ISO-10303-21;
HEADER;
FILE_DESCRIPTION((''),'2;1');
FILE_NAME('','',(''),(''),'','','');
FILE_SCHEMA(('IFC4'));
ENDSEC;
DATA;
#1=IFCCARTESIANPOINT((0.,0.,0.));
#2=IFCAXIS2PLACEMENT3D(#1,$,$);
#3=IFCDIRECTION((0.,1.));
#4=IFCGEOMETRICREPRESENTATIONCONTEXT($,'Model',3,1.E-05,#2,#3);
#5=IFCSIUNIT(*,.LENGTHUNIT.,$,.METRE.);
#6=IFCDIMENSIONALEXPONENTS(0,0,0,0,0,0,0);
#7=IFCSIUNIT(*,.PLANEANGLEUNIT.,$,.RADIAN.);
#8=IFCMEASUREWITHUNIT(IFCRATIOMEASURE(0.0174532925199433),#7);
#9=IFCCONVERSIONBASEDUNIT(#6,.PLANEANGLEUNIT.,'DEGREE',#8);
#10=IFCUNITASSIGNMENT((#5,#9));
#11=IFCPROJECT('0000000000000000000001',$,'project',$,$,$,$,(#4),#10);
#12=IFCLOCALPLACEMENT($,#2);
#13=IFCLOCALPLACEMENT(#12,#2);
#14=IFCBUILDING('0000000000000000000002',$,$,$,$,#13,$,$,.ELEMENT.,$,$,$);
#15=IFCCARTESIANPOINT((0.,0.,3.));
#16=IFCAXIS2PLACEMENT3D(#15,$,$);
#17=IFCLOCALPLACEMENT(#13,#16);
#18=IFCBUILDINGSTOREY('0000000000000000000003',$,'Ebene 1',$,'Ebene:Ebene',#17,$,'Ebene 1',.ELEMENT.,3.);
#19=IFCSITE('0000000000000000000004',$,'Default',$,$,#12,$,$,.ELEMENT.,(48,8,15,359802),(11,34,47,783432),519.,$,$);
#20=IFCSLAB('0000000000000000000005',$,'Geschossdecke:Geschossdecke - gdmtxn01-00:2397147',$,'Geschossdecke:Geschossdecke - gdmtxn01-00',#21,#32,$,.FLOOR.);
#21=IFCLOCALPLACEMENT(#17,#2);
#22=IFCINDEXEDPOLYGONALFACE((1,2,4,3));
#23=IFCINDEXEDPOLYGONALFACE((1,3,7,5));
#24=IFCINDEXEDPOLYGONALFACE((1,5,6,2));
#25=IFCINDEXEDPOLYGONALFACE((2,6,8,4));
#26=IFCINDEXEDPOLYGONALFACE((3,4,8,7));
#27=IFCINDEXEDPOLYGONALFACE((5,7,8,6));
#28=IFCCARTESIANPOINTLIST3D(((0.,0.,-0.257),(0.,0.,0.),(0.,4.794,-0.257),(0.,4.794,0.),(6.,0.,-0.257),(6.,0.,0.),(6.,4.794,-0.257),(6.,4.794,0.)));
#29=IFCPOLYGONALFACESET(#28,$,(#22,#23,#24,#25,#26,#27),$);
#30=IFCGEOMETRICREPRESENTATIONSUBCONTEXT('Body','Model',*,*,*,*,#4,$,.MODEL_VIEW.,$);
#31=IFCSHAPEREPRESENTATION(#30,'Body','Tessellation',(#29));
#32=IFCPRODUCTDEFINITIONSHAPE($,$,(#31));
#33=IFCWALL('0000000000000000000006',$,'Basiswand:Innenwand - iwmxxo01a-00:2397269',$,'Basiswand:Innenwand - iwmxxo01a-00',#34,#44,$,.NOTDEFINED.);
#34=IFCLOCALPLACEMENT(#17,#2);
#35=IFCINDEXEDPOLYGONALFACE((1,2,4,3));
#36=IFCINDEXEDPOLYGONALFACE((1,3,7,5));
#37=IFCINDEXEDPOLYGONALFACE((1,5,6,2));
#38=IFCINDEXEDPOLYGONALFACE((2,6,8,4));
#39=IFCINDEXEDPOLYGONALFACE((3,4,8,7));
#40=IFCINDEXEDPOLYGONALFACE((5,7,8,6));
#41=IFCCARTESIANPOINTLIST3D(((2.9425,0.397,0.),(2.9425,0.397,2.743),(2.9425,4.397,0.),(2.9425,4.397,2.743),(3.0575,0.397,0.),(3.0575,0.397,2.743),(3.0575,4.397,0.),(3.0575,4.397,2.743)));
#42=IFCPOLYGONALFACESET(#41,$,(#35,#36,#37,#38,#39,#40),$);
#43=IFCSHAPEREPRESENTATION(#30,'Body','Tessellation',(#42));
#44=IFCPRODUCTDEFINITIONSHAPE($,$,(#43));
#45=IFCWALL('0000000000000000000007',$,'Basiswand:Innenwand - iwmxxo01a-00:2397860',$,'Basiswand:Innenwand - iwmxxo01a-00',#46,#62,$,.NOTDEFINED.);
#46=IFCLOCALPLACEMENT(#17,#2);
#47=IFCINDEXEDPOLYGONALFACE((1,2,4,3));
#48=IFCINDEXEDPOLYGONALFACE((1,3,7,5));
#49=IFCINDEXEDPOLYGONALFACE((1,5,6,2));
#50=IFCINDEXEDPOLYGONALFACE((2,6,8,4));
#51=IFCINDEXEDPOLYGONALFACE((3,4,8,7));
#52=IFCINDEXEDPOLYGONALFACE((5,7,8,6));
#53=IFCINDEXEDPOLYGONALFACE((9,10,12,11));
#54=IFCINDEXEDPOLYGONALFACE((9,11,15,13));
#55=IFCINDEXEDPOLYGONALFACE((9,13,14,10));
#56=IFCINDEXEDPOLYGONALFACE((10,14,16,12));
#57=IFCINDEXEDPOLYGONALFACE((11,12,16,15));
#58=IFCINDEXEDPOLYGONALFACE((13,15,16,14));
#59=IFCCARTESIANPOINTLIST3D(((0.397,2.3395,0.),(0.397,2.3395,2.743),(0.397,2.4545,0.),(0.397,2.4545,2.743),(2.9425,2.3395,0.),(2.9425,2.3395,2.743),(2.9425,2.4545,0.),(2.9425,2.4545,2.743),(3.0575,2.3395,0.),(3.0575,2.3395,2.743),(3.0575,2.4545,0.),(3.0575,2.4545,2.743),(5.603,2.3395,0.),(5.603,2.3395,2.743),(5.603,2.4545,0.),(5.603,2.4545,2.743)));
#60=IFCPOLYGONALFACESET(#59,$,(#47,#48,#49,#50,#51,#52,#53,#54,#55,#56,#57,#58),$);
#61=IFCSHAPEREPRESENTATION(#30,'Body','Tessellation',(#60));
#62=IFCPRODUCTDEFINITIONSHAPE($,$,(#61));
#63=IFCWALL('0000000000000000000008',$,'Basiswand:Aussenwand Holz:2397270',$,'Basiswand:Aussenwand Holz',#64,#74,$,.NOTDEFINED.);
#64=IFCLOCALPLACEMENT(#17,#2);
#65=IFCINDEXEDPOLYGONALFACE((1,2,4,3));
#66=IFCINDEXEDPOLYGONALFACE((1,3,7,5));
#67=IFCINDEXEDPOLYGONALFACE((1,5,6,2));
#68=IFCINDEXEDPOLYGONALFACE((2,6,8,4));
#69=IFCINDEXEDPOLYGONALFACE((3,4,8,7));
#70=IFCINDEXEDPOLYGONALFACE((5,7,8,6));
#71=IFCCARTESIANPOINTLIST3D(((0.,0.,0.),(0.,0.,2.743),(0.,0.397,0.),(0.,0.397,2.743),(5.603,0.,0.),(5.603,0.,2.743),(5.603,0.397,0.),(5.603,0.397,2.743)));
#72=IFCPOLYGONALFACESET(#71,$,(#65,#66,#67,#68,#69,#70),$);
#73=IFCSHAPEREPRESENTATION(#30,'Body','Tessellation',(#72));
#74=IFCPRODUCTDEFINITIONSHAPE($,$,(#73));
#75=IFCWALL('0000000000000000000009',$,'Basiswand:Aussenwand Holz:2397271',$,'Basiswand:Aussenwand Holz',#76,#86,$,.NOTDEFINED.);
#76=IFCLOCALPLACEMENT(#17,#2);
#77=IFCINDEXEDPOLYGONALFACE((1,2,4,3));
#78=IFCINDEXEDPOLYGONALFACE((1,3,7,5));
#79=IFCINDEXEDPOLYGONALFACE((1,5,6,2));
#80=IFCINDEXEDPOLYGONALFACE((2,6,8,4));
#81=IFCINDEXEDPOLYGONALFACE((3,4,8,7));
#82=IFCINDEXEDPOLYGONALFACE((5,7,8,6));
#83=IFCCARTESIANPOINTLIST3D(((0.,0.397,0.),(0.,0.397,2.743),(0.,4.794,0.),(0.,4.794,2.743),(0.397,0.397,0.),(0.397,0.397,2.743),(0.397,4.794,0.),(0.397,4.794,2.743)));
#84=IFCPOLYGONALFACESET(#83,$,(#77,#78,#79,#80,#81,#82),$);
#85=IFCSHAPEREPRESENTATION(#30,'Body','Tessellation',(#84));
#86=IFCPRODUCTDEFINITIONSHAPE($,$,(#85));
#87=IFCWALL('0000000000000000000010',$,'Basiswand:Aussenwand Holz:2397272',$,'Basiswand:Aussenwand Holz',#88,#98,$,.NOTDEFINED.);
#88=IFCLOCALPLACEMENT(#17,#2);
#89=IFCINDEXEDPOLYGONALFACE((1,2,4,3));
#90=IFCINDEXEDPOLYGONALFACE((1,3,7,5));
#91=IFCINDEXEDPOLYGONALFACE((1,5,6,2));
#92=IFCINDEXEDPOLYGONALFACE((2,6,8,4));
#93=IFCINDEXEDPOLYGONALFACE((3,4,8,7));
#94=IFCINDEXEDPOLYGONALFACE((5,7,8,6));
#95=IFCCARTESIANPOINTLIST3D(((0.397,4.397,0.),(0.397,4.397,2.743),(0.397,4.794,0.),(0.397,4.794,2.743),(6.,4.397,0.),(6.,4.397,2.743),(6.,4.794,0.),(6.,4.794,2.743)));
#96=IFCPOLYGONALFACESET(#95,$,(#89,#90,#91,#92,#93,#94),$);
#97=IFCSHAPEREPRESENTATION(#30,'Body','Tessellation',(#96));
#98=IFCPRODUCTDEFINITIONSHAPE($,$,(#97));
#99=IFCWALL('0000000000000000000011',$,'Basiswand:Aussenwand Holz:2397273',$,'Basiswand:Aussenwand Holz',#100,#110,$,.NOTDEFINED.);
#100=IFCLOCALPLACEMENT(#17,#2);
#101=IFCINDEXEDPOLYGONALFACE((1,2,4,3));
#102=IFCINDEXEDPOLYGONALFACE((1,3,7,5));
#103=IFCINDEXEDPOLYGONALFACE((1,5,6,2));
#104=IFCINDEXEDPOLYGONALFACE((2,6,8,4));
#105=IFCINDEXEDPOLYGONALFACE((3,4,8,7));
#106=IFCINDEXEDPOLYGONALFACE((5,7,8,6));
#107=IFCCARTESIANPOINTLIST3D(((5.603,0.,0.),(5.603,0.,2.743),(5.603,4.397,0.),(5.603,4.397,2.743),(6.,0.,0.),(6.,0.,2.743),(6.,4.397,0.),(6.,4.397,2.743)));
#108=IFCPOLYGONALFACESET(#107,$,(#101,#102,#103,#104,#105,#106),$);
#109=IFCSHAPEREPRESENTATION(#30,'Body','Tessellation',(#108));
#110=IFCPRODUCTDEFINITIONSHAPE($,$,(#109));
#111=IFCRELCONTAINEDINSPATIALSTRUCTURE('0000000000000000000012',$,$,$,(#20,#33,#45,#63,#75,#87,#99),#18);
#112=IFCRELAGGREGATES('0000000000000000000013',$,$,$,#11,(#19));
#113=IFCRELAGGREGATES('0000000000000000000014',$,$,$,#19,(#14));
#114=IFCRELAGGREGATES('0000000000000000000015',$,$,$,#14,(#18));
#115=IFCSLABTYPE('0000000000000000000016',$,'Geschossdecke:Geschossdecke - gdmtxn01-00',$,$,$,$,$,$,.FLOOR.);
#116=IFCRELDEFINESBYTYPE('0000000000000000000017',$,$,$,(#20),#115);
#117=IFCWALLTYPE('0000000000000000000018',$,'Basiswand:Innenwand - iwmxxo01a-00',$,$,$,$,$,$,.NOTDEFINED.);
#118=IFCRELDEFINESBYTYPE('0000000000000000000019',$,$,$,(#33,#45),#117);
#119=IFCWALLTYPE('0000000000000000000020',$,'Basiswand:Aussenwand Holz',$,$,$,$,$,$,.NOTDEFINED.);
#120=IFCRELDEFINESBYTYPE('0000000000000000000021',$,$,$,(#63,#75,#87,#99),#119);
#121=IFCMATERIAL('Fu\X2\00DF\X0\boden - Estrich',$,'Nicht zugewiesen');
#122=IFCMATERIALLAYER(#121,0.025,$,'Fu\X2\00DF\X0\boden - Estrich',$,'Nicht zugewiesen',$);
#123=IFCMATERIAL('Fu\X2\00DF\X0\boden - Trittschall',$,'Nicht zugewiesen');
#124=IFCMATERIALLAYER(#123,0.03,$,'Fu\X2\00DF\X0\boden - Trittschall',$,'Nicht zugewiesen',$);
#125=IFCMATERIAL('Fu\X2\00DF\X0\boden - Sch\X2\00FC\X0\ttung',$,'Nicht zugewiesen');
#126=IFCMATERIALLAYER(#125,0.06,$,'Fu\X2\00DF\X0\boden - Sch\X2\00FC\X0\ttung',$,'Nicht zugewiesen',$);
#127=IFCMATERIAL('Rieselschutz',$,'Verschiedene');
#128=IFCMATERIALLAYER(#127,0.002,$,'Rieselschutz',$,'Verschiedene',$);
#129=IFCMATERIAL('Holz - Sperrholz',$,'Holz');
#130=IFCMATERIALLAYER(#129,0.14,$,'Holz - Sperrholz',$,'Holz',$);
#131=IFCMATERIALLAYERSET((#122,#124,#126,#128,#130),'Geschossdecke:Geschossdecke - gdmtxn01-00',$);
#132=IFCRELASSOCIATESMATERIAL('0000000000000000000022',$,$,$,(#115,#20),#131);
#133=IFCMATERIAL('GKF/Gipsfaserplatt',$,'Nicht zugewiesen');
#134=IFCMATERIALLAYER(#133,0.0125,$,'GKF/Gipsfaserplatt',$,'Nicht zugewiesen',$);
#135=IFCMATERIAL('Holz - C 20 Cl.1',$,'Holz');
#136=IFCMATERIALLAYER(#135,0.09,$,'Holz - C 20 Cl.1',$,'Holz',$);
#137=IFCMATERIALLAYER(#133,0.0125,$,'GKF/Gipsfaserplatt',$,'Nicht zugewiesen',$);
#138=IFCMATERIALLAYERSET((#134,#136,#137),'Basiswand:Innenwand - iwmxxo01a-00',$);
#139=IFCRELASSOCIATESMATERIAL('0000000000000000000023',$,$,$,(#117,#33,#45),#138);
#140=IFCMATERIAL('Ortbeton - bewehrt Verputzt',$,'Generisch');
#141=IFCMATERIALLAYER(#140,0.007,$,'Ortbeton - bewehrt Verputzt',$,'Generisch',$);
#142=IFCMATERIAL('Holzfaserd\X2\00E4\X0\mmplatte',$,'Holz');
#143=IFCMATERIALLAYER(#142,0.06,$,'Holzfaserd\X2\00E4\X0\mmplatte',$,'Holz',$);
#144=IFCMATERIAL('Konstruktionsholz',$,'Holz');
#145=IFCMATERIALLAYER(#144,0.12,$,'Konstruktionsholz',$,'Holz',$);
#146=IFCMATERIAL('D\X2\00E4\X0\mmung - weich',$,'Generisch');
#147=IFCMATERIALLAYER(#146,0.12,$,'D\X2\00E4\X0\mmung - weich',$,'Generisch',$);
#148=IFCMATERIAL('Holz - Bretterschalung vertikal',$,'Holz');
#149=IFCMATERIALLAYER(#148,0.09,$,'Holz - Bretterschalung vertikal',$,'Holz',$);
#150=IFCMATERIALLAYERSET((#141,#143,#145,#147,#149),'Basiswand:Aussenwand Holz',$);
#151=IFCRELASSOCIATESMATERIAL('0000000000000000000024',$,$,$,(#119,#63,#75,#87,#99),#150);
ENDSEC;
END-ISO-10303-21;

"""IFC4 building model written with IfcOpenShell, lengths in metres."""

from ifc_helpers import new_model, entity, si_unit, converted_unit, direction, frame, frame_2d, origin, place, context, subcontext, project, spatial, rectangle, extrude, material, layer, layer_set, layer_usage, type_object, element, save


model = new_model("IFC4")

# Units and contexts
model_context = context("Model", 3, precision=1e-05, world=origin(), true_north=direction((0.0, 1.0)))
body_context = subcontext(model_context, "Body", "Model", "MODEL_VIEW")
ifc_project = project(units=[si_unit("LENGTHUNIT", "METRE"), converted_unit("PLANEANGLEUNIT", "DEGREE", entity("IfcRatioMeasure", 0.0174532925199433), si_unit("PLANEANGLEUNIT", "RADIAN"), dimensions=[0, 0, 0, 0, 0, 0, 0])], contexts=[model_context])

# Site, building, storey
site_placement = place(None, frame((0.0, 0.0, 0.0)))
site = spatial("IfcSite", under=ifc_project, at=site_placement, Name="Default", CompositionType="ELEMENT", RefLatitude=(48, 8, 15, 359802), RefLongitude=(11, 34, 47, 783432), RefElevation=519.0)
building_placement = place(site_placement, origin())
building = spatial("IfcBuilding", under=site, at=building_placement, CompositionType="ELEMENT")
storey_placement = place(building_placement, frame((0.0, 0.0, 3.0)))
storey = spatial("IfcBuildingStorey", under=building, at=storey_placement, Name="Ebene 1", ObjectType="Ebene:Ebene", LongName="Ebene 1", CompositionType="ELEMENT", Elevation=3.0)

# Slab
ifc_material_1 = material(Name="Fußboden - Estrich", Category="Nicht zugewiesen")
ifc_layer_1 = layer(ifc_material_1, 0.025, Name="Fußboden - Estrich", Category="Nicht zugewiesen")
ifc_material_2 = material(Name="Fußboden - Trittschall", Category="Nicht zugewiesen")
ifc_layer_2 = layer(ifc_material_2, 0.03, Name="Fußboden - Trittschall", Category="Nicht zugewiesen")
ifc_material_3 = material(Name="Fußboden - Schüttung", Category="Nicht zugewiesen")
ifc_layer_3 = layer(ifc_material_3, 0.06, Name="Fußboden - Schüttung", Category="Nicht zugewiesen")
ifc_material_4 = material(Name="Rieselschutz", Category="Verschiedene")
ifc_layer_4 = layer(ifc_material_4, 0.002, Name="Rieselschutz", Category="Verschiedene")
ifc_material_5 = material(Name="Holz - Sperrholz", Category="Holz")
ifc_layer_5 = layer(ifc_material_5, 0.14, Name="Holz - Sperrholz", Category="Holz")
ifc_layer_set_1 = layer_set([ifc_layer_1, ifc_layer_2, ifc_layer_3, ifc_layer_4, ifc_layer_5], Name="Geschossdecke:Geschossdecke - gdmtxn01-00")
ifc_layer_usage_1 = layer_usage(ifc_layer_set_1, "AXIS3", "POSITIVE", 0.0)
slab_type = type_object("IfcSlabType", Name="Geschossdecke:Geschossdecke - gdmtxn01-00", PredefinedType="FLOOR", material=ifc_layer_set_1)
slab_placement = place(storey_placement, origin())
element("IfcSlab", 1, at=slab_placement, inside=storey, type_object=slab_type, material=ifc_layer_usage_1, Name="Geschossdecke:Geschossdecke - gdmtxn01-00:2397147", ObjectType="Geschossdecke:Geschossdecke - gdmtxn01-00", PredefinedType="FLOOR", context=body_context, shape_type="SweptSolid", body=[
    extrude(rectangle(XDim=4.794, YDim=6.0, at=frame_2d((0.0, 0.0), x_axis=(1.0, 0.0))), frame((3.0, 2.397, 0.0), z_axis=(0.0, 0.0, -1.0), x_axis=(0.0, 1.0, 0.0)), (0.0, 0.0, 1.0), 0.257),
])

# Wall
ifc_material_6 = material(Name="GKF/Gipsfaserplatt", Category="Nicht zugewiesen")
ifc_layer_6 = layer(ifc_material_6, 0.0125, Name="GKF/Gipsfaserplatt", Category="Nicht zugewiesen")
ifc_material_7 = material(Name="Holz - C 20 Cl.1", Category="Holz")
ifc_layer_7 = layer(ifc_material_7, 0.09, Name="Holz - C 20 Cl.1", Category="Holz")
ifc_layer_8 = layer(ifc_material_6, 0.0125, Name="GKF/Gipsfaserplatt", Category="Nicht zugewiesen")
ifc_layer_set_2 = layer_set([ifc_layer_6, ifc_layer_7, ifc_layer_8], Name="Basiswand:Innenwand - iwmxxo01a-00")
ifc_layer_usage_2 = layer_usage(ifc_layer_set_2, "AXIS2", "NEGATIVE", 0.0575)
wall_type_1 = type_object("IfcWallType", Name="Basiswand:Innenwand - iwmxxo01a-00", PredefinedType="NOTDEFINED", material=ifc_layer_set_2)
wall_1_placement = place(storey_placement, frame((3.0, 0.397, 0.0), z_axis=(0.0, 0.0, 1.0), x_axis=(0.0, 1.0, 0.0)))
element("IfcWall", 2, at=wall_1_placement, inside=storey, type_object=wall_type_1, material=ifc_layer_usage_2, Name="Basiswand:Innenwand - iwmxxo01a-00:2397269", ObjectType="Basiswand:Innenwand - iwmxxo01a-00", PredefinedType="NOTDEFINED", context=body_context, shape_type="SweptSolid", body=[
    extrude(rectangle(XDim=4.0, YDim=0.115, at=frame_2d((2.0, 0.0), x_axis=(-1.0, 0.0))), origin(), (0.0, 0.0, 1.0), 2.743),
])

# Wall, opening
ifc_layer_usage_3 = layer_usage(ifc_layer_set_2, "AXIS2", "NEGATIVE", 0.0575)
wall_2_placement = place(storey_placement, frame((0.397, 2.397, 0.0)))
wall_2 = element("IfcWall", 3, at=wall_2_placement, inside=storey, type_object=wall_type_1, material=ifc_layer_usage_3, Name="Basiswand:Innenwand - iwmxxo01a-00:2397860", ObjectType="Basiswand:Innenwand - iwmxxo01a-00", PredefinedType="NOTDEFINED", context=body_context, shape_type="SweptSolid", body=[
    extrude(rectangle(XDim=5.206, YDim=0.115, at=frame_2d((2.603, 0.0), x_axis=(-1.0, 0.0))), origin(), (0.0, 0.0, 1.0), 2.743),
])
opening_placement = place(storey_placement, frame((0.397, 2.397, 0.0)))
element("IfcOpeningElement", 4, at=opening_placement, cuts=wall_2, ObjectType="Opening", PredefinedType="OPENING", context=body_context, shape_type="SweptSolid", body=[
    extrude(rectangle(XDim=2.743, YDim=0.115, at=frame_2d((0.0, 0.0), x_axis=(1.0, 0.0))), frame((2.5455, 0.0, 1.3715), z_axis=(1.0, 0.0, 0.0), x_axis=(0.0, 0.0, -1.0)), (0.0, 0.0, 1.0), 0.115),
])

# Walls
ifc_material_8 = material(Name="Ortbeton - bewehrt Verputzt", Category="Generisch")
ifc_layer_9 = layer(ifc_material_8, 0.007, Name="Ortbeton - bewehrt Verputzt", Category="Generisch")
ifc_material_9 = material(Name="Holzfaserdämmplatte", Category="Holz")
ifc_layer_10 = layer(ifc_material_9, 0.06, Name="Holzfaserdämmplatte", Category="Holz")
ifc_material_10 = material(Name="Konstruktionsholz", Category="Holz")
ifc_layer_11 = layer(ifc_material_10, 0.12, Name="Konstruktionsholz", Category="Holz")
ifc_material_11 = material(Name="Dämmung - weich", Category="Generisch")
ifc_layer_12 = layer(ifc_material_11, 0.12, Name="Dämmung - weich", Category="Generisch")
ifc_material_12 = material(Name="Holz - Bretterschalung vertikal", Category="Holz")
ifc_layer_13 = layer(ifc_material_12, 0.09, Name="Holz - Bretterschalung vertikal", Category="Holz")
ifc_layer_set_3 = layer_set([ifc_layer_9, ifc_layer_10, ifc_layer_11, ifc_layer_12, ifc_layer_13], Name="Basiswand:Aussenwand Holz")
ifc_layer_usage_4 = layer_usage(ifc_layer_set_3, "AXIS2", "NEGATIVE", 0.1985)
wall_type_2 = type_object("IfcWallType", Name="Basiswand:Aussenwand Holz", PredefinedType="NOTDEFINED", material=ifc_layer_set_3)
wall_3_placement = place(storey_placement, frame((0.0, 0.1985, 0.0)))
element("IfcWall", 5, at=wall_3_placement, inside=storey, type_object=wall_type_2, material=ifc_layer_usage_4, Name="Basiswand:Aussenwand Holz:2397270", ObjectType="Basiswand:Aussenwand Holz", PredefinedType="NOTDEFINED", context=body_context, shape_type="SweptSolid", body=[
    extrude(rectangle(XDim=5.603, YDim=0.397, at=frame_2d((2.8015, 0.0), x_axis=(-1.0, 0.0))), origin(), (0.0, 0.0, 1.0), 2.743),
])
ifc_layer_usage_5 = layer_usage(ifc_layer_set_3, "AXIS2", "NEGATIVE", 0.1985)
wall_4_placement = place(storey_placement, frame((0.1985, 4.794, 0.0), z_axis=(0.0, 0.0, 1.0), x_axis=(0.0, -1.0, 0.0)))
element("IfcWall", 6, at=wall_4_placement, inside=storey, type_object=wall_type_2, material=ifc_layer_usage_5, Name="Basiswand:Aussenwand Holz:2397271", ObjectType="Basiswand:Aussenwand Holz", PredefinedType="NOTDEFINED", context=body_context, shape_type="SweptSolid", body=[
    extrude(rectangle(XDim=4.397, YDim=0.397, at=frame_2d((2.1985, 0.0), x_axis=(-1.0, 0.0))), origin(), (0.0, 0.0, 1.0), 2.743),
])
ifc_layer_usage_6 = layer_usage(ifc_layer_set_3, "AXIS2", "NEGATIVE", 0.1985)
wall_5_placement = place(storey_placement, frame((6.0, 4.5955, 0.0), z_axis=(0.0, 0.0, 1.0), x_axis=(-1.0, 0.0, 0.0)))
element("IfcWall", 7, at=wall_5_placement, inside=storey, type_object=wall_type_2, material=ifc_layer_usage_6, Name="Basiswand:Aussenwand Holz:2397272", ObjectType="Basiswand:Aussenwand Holz", PredefinedType="NOTDEFINED", context=body_context, shape_type="SweptSolid", body=[
    extrude(rectangle(XDim=5.603, YDim=0.397, at=frame_2d((2.8015, 0.0), x_axis=(-1.0, 0.0))), origin(), (0.0, 0.0, 1.0), 2.743),
])
ifc_layer_usage_7 = layer_usage(ifc_layer_set_3, "AXIS2", "NEGATIVE", 0.1985)
wall_6_placement = place(storey_placement, frame((5.8015, 0.0, 0.0), z_axis=(0.0, 0.0, 1.0), x_axis=(0.0, 1.0, 0.0)))
element("IfcWall", 8, at=wall_6_placement, inside=storey, type_object=wall_type_2, material=ifc_layer_usage_7, Name="Basiswand:Aussenwand Holz:2397273", ObjectType="Basiswand:Aussenwand Holz", PredefinedType="NOTDEFINED", context=body_context, shape_type="SweptSolid", body=[
    extrude(rectangle(XDim=4.397, YDim=0.397, at=frame_2d((2.1985, 0.0), x_axis=(-1.0, 0.0))), origin(), (0.0, 0.0, 1.0), 2.743),
])

save(model, "model.ifc")
